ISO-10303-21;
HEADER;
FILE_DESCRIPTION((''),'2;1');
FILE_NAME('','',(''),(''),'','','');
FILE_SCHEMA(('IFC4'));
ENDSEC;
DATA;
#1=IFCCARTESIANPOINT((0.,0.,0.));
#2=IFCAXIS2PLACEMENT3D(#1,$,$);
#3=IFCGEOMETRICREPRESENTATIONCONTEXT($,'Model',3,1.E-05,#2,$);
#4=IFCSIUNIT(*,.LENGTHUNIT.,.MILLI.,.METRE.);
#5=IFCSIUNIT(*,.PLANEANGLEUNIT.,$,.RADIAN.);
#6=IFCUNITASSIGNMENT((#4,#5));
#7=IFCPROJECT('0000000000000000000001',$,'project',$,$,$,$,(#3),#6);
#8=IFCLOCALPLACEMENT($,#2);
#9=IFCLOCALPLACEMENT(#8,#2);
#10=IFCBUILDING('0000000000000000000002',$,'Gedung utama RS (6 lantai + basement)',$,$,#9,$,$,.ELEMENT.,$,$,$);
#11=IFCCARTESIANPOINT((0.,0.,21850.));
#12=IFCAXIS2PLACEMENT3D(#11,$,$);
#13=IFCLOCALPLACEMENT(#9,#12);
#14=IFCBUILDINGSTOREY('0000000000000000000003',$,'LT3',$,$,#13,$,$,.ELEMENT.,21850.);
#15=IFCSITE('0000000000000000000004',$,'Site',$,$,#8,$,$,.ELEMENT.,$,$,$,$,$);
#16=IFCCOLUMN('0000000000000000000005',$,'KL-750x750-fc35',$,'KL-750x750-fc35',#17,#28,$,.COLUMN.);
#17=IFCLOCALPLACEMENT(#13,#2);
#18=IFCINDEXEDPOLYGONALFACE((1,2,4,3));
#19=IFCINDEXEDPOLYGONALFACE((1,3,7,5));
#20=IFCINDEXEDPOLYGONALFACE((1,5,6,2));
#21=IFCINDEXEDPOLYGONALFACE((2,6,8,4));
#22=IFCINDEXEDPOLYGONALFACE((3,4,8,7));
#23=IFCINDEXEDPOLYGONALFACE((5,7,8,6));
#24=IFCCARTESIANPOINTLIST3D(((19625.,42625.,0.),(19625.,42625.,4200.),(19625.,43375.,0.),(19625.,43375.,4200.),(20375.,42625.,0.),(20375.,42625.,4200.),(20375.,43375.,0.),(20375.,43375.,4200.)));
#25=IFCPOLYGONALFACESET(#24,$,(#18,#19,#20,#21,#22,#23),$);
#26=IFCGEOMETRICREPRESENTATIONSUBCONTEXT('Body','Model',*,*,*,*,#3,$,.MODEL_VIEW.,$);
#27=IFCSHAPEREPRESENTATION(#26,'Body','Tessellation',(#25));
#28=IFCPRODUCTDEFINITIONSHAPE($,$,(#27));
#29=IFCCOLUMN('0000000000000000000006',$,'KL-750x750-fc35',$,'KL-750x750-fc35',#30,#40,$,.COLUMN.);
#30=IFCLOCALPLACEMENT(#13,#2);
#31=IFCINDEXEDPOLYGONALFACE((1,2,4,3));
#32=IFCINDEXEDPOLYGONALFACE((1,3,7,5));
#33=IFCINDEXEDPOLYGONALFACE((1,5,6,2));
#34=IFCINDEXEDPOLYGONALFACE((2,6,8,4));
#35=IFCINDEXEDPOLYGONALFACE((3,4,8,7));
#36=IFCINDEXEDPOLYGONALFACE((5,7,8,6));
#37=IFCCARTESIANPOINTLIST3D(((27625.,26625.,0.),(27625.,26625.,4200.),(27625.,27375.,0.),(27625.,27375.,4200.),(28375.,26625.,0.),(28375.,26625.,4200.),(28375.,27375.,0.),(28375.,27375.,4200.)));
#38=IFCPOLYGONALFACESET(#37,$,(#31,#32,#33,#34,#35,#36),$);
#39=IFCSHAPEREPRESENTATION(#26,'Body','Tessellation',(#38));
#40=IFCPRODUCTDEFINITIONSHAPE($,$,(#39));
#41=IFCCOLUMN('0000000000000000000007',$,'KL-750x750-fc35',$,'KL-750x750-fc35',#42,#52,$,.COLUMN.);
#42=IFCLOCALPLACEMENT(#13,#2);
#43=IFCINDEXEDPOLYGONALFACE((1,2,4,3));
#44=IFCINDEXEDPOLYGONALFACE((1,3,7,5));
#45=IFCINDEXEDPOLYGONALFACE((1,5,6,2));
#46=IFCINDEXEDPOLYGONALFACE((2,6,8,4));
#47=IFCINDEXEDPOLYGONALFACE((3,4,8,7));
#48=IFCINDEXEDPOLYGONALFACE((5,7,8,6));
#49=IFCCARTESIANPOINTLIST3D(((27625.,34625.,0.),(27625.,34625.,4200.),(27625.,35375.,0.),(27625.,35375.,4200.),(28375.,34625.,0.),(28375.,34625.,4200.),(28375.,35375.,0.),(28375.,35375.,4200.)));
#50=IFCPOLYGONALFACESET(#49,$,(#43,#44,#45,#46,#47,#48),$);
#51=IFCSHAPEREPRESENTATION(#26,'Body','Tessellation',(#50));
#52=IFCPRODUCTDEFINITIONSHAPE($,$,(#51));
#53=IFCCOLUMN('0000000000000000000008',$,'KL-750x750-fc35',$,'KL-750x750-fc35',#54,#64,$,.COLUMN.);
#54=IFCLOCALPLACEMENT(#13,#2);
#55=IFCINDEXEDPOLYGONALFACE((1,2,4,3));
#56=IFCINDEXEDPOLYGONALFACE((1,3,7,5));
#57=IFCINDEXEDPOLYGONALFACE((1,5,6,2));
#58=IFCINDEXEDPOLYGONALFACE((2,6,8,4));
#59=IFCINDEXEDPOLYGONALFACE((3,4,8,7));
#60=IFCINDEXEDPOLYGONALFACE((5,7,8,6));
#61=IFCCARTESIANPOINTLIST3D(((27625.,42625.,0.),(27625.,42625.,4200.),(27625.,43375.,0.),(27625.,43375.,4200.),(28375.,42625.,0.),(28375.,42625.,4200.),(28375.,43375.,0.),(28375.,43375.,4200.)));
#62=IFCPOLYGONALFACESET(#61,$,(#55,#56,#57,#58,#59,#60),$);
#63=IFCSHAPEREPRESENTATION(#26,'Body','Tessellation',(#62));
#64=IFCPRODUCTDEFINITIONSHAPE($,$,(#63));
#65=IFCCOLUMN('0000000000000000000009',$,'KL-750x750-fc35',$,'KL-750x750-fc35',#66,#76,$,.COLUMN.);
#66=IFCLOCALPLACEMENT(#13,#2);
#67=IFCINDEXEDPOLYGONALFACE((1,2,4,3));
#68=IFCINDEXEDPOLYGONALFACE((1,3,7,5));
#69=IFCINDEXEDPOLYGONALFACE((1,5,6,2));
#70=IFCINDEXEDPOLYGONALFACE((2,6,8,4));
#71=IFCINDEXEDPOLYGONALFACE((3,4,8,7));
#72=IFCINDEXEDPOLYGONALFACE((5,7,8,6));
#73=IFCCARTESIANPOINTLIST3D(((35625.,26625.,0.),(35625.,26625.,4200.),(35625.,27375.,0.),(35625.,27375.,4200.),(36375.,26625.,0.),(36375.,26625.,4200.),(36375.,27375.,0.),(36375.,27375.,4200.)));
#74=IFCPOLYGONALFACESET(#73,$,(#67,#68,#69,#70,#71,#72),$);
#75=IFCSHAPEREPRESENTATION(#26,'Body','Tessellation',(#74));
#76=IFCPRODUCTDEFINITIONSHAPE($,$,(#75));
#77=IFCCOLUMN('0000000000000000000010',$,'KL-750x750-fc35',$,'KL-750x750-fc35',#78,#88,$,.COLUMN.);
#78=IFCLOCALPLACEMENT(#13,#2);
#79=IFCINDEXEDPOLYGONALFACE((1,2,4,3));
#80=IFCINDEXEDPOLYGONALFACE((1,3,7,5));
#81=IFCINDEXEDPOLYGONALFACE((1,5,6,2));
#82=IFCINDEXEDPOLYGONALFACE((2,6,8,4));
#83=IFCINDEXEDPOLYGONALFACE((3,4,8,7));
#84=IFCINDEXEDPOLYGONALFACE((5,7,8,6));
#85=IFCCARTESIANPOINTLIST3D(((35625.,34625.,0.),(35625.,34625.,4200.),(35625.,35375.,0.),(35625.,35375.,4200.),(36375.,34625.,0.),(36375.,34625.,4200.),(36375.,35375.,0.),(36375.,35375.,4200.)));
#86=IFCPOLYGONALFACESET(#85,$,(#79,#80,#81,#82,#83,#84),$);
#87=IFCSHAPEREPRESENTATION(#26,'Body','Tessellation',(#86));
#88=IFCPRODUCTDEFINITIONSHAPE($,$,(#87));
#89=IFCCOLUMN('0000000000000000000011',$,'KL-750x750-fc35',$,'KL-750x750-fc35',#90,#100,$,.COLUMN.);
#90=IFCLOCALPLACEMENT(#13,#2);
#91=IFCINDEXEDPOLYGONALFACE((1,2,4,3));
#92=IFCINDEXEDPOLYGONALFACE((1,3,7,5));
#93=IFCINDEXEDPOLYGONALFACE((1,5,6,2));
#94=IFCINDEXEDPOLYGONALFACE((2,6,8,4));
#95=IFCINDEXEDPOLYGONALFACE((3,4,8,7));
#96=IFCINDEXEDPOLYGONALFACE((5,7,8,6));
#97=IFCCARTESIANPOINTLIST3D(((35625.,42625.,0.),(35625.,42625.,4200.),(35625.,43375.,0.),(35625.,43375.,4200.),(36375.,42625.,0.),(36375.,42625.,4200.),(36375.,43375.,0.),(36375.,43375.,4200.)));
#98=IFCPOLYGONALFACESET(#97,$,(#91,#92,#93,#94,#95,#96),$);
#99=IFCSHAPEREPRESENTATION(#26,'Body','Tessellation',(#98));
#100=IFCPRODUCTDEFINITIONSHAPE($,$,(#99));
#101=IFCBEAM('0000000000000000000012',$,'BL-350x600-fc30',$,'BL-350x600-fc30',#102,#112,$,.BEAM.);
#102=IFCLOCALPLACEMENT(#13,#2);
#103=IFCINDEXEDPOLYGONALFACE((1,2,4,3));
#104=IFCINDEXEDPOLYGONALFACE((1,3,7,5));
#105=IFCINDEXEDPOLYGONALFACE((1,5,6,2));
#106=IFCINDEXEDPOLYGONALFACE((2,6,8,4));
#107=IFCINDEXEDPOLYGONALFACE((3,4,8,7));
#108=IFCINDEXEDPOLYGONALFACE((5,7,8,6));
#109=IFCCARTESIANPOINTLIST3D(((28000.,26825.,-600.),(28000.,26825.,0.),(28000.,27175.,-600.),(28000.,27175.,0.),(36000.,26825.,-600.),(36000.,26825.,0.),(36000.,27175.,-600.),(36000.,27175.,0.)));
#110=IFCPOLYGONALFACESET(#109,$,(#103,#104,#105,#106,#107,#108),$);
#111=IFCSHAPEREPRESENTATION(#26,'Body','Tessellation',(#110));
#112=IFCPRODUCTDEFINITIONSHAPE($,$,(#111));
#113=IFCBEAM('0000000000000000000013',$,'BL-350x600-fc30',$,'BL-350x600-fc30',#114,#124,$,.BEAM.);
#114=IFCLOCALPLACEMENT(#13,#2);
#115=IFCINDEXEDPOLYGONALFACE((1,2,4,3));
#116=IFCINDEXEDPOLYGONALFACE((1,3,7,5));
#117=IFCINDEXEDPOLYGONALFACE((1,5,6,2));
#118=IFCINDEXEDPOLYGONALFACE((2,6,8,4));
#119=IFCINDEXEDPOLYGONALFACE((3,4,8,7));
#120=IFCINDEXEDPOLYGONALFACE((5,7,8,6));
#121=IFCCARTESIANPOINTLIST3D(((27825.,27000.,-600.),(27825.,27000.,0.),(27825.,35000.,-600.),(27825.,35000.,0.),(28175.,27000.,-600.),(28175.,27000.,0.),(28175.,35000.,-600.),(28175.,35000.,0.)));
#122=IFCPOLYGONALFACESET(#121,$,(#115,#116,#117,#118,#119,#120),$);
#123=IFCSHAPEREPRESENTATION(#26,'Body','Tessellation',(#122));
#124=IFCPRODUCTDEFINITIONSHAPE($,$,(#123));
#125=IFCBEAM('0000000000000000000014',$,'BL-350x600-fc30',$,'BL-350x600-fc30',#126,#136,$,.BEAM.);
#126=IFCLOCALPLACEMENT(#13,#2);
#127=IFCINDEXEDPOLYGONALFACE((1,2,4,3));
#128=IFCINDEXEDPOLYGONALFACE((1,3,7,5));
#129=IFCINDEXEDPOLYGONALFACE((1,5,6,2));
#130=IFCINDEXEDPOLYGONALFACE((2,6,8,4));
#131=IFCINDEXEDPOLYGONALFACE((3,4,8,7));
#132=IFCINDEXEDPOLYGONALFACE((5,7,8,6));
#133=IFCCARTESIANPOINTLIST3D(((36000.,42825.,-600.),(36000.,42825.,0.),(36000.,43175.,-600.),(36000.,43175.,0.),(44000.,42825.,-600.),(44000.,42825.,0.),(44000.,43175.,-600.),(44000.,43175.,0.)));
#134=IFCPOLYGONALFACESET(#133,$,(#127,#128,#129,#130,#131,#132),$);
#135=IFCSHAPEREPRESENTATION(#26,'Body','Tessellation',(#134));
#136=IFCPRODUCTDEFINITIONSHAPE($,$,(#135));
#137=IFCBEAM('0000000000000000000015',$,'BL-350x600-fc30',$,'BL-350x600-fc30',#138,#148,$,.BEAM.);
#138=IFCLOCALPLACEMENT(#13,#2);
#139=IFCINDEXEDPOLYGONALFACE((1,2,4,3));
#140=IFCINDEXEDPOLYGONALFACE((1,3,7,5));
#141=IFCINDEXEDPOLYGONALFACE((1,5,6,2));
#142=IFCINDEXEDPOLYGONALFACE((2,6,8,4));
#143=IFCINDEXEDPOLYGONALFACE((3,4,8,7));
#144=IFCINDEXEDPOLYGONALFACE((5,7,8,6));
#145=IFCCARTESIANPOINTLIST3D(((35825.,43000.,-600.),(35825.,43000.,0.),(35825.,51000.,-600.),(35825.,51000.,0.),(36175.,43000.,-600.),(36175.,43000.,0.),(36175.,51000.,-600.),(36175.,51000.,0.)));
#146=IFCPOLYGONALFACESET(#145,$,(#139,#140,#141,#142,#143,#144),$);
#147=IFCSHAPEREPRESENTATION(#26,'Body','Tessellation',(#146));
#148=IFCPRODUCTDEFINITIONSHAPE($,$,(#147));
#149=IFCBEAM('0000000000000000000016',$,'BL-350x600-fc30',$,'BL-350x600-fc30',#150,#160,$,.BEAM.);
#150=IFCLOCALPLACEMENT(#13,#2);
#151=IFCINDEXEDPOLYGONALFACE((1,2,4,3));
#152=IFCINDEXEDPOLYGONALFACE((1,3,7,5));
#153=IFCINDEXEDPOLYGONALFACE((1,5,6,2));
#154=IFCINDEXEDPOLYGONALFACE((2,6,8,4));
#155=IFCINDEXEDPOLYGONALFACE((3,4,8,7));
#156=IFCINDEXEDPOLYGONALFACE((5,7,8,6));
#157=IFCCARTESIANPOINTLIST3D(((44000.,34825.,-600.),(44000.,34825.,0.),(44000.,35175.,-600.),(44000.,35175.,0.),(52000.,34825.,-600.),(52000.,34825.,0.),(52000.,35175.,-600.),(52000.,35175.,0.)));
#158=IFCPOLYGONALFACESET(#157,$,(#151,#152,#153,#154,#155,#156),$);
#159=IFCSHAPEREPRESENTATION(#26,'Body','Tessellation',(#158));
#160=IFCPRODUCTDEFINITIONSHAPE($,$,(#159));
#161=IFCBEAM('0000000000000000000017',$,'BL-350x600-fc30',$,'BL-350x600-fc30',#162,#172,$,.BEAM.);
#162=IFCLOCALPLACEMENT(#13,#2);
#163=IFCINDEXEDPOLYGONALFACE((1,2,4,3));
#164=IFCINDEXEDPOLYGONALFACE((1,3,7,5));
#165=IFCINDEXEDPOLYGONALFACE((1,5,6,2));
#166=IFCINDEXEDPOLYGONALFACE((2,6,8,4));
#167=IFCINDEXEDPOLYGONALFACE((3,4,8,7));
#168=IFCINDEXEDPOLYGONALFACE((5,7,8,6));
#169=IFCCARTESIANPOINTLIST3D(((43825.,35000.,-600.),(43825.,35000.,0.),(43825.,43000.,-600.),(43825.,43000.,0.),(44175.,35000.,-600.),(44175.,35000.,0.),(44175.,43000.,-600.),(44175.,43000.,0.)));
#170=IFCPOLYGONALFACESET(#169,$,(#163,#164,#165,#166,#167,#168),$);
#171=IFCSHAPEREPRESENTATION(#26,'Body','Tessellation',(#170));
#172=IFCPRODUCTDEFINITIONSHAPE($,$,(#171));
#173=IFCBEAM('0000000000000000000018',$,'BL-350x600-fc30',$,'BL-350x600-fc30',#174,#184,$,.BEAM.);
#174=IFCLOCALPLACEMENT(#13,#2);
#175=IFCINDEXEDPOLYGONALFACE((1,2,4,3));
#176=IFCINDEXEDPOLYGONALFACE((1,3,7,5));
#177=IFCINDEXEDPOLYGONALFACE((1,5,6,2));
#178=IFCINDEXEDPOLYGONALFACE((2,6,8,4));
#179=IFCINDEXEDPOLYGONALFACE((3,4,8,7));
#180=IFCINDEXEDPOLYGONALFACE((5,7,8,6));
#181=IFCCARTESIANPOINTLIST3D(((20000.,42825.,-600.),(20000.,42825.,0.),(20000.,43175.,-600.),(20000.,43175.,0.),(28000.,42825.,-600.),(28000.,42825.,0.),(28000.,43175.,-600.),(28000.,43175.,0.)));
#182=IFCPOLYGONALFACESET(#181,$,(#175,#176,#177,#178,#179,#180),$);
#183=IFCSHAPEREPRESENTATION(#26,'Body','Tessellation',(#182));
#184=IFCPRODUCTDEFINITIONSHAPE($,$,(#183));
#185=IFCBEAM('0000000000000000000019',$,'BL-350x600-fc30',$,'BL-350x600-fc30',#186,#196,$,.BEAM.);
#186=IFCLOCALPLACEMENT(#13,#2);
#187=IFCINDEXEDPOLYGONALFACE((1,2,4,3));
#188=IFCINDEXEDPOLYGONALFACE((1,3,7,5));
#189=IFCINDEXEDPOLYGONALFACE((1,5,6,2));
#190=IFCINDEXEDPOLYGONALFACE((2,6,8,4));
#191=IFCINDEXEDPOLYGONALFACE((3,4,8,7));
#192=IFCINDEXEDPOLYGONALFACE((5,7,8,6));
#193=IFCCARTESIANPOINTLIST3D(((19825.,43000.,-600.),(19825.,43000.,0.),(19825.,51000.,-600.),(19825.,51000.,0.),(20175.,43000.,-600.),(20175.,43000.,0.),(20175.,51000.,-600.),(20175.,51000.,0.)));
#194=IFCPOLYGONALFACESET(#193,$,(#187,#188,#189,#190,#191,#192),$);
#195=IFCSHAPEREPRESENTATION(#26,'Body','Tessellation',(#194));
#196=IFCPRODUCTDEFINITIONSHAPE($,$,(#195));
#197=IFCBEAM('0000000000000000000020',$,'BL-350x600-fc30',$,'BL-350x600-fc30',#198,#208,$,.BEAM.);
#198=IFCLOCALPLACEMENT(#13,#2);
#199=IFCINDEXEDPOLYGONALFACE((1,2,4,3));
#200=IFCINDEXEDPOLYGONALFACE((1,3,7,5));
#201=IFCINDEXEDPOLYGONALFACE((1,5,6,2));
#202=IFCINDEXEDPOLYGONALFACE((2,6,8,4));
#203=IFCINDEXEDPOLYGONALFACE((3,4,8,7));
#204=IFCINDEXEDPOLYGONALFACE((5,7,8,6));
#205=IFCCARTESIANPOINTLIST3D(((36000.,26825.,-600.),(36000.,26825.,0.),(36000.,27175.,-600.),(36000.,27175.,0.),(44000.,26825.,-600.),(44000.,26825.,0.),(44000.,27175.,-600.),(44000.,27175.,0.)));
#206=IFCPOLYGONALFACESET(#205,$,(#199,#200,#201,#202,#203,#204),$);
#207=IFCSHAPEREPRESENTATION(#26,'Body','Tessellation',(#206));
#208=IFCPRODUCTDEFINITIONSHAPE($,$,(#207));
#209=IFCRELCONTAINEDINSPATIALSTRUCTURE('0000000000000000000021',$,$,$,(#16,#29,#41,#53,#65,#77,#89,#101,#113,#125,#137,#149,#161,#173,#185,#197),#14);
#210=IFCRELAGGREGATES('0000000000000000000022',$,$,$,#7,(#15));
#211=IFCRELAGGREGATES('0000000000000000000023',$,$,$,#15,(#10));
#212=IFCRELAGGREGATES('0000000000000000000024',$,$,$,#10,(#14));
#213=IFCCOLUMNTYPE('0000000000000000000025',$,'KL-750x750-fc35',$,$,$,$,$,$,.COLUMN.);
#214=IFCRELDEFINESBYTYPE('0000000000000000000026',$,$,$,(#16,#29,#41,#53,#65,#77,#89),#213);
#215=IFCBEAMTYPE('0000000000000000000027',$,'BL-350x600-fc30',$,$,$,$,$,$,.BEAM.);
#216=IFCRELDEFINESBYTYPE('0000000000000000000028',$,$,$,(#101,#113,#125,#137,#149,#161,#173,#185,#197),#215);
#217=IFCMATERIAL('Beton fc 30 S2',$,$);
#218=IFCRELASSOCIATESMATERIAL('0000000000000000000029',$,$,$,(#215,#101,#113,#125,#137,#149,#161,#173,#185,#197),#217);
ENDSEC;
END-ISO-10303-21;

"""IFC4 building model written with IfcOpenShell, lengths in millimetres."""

from ifc_helpers import new_model, si_unit, frame, origin, origin_2d, place, context, subcontext, project, spatial, rectangle, extrude, material, material_profile, profile_set, profile_usage, type_object, element, save


model = new_model("IFC4")

# Units and contexts
model_context = context("Model", 3, precision=1e-05, world=origin())
body_context = subcontext(model_context, "Body", "Model", "MODEL_VIEW")
ifc_project = project(units=[si_unit("LENGTHUNIT", "METRE", prefix="MILLI"), si_unit("PLANEANGLEUNIT", "RADIAN")], contexts=[model_context])

# Site, building, storey
site_placement = place(None, origin())
site = spatial("IfcSite", under=ifc_project, at=site_placement, Name="Site", CompositionType="ELEMENT")
building_placement = place(site_placement, origin())
building = spatial("IfcBuilding", under=site, at=building_placement, Name="Gedung utama RS (6 lantai + basement)", CompositionType="ELEMENT")
storey_placement = place(building_placement, frame((0.0, 0.0, 21850.0)))
storey = spatial("IfcBuildingStorey", under=building, at=storey_placement, Name="LT3", CompositionType="ELEMENT", Elevation=21850.0)

# Columns
ifc_material_profile_1 = material_profile(None, rectangle(XDim=750.0, YDim=750.0, at=origin_2d()), Name="KL-750x750-fc35")
ifc_profile_set_1 = profile_set([ifc_material_profile_1], Name="KL-750x750-fc35")
ifc_profile_usage_1 = profile_usage(ifc_profile_set_1, cardinal=5)
column_type = type_object("IfcColumnType", Name="KL-750x750-fc35", PredefinedType="COLUMN", material=ifc_profile_set_1)
for number, where, z_axis, x_axis, name in (
    (1, (20000.0, 43000.0, 0.0), (0.0, 0.0, 1.0), (1.0, 0.0, 0.0), "KL-750x750-fc35"),
    (2, (28000.0, 27000.0, 0.0), (0.0, 0.0, 1.0), (1.0, 0.0, 0.0), "KL-750x750-fc35"),
    (3, (28000.0, 35000.0, 0.0), (0.0, 0.0, 1.0), (1.0, 0.0, 0.0), "KL-750x750-fc35"),
    (4, (28000.0, 43000.0, 0.0), (0.0, 0.0, 1.0), (1.0, 0.0, 0.0), "KL-750x750-fc35"),
    (5, (36000.0, 27000.0, 0.0), (0.0, 0.0, 1.0), (1.0, 0.0, 0.0), "KL-750x750-fc35"),
    (6, (36000.0, 35000.0, 0.0), (0.0, 0.0, 1.0), (1.0, 0.0, 0.0), "KL-750x750-fc35"),
    (7, (36000.0, 43000.0, 0.0), (0.0, 0.0, 1.0), (1.0, 0.0, 0.0), "KL-750x750-fc35"),
):
    element("IfcColumn", number, at=place(storey_placement, frame(where, z_axis=z_axis, x_axis=x_axis)), inside=storey, type_object=column_type, material=ifc_profile_usage_1, Name=name, ObjectType="KL-750x750-fc35", PredefinedType="COLUMN", context=body_context, shape_type="SweptSolid", body=[
        extrude(rectangle(XDim=750.0, YDim=750.0, at=origin_2d()), origin(), (0.0, 0.0, 1.0), 4200.0),
    ])

# Beams
ifc_material_1 = material(Name="Beton fc 30 S2")
ifc_material_profile_2 = material_profile(ifc_material_1, rectangle(XDim=350.0, YDim=600.0, at=origin_2d()), Name="BL-350x600-fc30")
ifc_profile_set_2 = profile_set([ifc_material_profile_2], Name="BL-350x600-fc30")
ifc_profile_usage_2 = profile_usage(ifc_profile_set_2, cardinal=8)
beam_type = type_object("IfcBeamType", Name="BL-350x600-fc30", PredefinedType="BEAM", material=ifc_profile_set_2)
beam_1_placement = place(storey_placement, frame((28000.0, 27000.0, -300.0)))
element("IfcBeam", 8, at=beam_1_placement, inside=storey, type_object=beam_type, material=ifc_profile_usage_2, Name="BL-350x600-fc30", ObjectType="BL-350x600-fc30", PredefinedType="BEAM", context=body_context, shape_type="SweptSolid", body=[
    extrude(rectangle(XDim=350.0, YDim=600.0, at=origin_2d()), frame((0.0, 0.0, 0.0), z_axis=(1.0, 0.0, 0.0), x_axis=(0.0, 1.0, 0.0)), (0.0, 0.0, 1.0), 8000.0),
])
beam_2_placement = place(storey_placement, frame((28000.0, 27000.0, -300.0)))
element("IfcBeam", 9, at=beam_2_placement, inside=storey, type_object=beam_type, material=ifc_profile_usage_2, Name="BL-350x600-fc30", ObjectType="BL-350x600-fc30", PredefinedType="BEAM", context=body_context, shape_type="SweptSolid", body=[
    extrude(rectangle(XDim=350.0, YDim=600.0, at=origin_2d()), frame((0.0, 0.0, 0.0), z_axis=(0.0, 1.0, 0.0), x_axis=(-1.0, 0.0, 0.0)), (0.0, 0.0, 1.0), 8000.0),
])
beam_3_placement = place(storey_placement, frame((36000.0, 43000.0, -300.0)))
element("IfcBeam", 10, at=beam_3_placement, inside=storey, type_object=beam_type, material=ifc_profile_usage_2, Name="BL-350x600-fc30", ObjectType="BL-350x600-fc30", PredefinedType="BEAM", context=body_context, shape_type="SweptSolid", body=[
    extrude(rectangle(XDim=350.0, YDim=600.0, at=origin_2d()), frame((0.0, 0.0, 0.0), z_axis=(1.0, 0.0, 0.0), x_axis=(0.0, 1.0, 0.0)), (0.0, 0.0, 1.0), 8000.0),
])
beam_4_placement = place(storey_placement, frame((36000.0, 43000.0, -300.0)))
element("IfcBeam", 11, at=beam_4_placement, inside=storey, type_object=beam_type, material=ifc_profile_usage_2, Name="BL-350x600-fc30", ObjectType="BL-350x600-fc30", PredefinedType="BEAM", context=body_context, shape_type="SweptSolid", body=[
    extrude(rectangle(XDim=350.0, YDim=600.0, at=origin_2d()), frame((0.0, 0.0, 0.0), z_axis=(0.0, 1.0, 0.0), x_axis=(-1.0, 0.0, 0.0)), (0.0, 0.0, 1.0), 8000.0),
])
beam_5_placement = place(storey_placement, frame((44000.0, 35000.0, -300.0)))
element("IfcBeam", 12, at=beam_5_placement, inside=storey, type_object=beam_type, material=ifc_profile_usage_2, Name="BL-350x600-fc30", ObjectType="BL-350x600-fc30", PredefinedType="BEAM", context=body_context, shape_type="SweptSolid", body=[
    extrude(rectangle(XDim=350.0, YDim=600.0, at=origin_2d()), frame((0.0, 0.0, 0.0), z_axis=(1.0, 0.0, 0.0), x_axis=(0.0, 1.0, 0.0)), (0.0, 0.0, 1.0), 8000.0),
])
beam_6_placement = place(storey_placement, frame((44000.0, 35000.0, -300.0)))
element("IfcBeam", 13, at=beam_6_placement, inside=storey, type_object=beam_type, material=ifc_profile_usage_2, Name="BL-350x600-fc30", ObjectType="BL-350x600-fc30", PredefinedType="BEAM", context=body_context, shape_type="SweptSolid", body=[
    extrude(rectangle(XDim=350.0, YDim=600.0, at=origin_2d()), frame((0.0, 0.0, 0.0), z_axis=(0.0, 1.0, 0.0), x_axis=(-1.0, 0.0, 0.0)), (0.0, 0.0, 1.0), 8000.0),
])
beam_7_placement = place(storey_placement, frame((20000.0, 43000.0, -300.0)))
element("IfcBeam", 14, at=beam_7_placement, inside=storey, type_object=beam_type, material=ifc_profile_usage_2, Name="BL-350x600-fc30", ObjectType="BL-350x600-fc30", PredefinedType="BEAM", context=body_context, shape_type="SweptSolid", body=[
    extrude(rectangle(XDim=350.0, YDim=600.0, at=origin_2d()), frame((0.0, 0.0, 0.0), z_axis=(1.0, 0.0, 0.0), x_axis=(0.0, 1.0, 0.0)), (0.0, 0.0, 1.0), 8000.0),
])
beam_8_placement = place(storey_placement, frame((20000.0, 43000.0, -300.0)))
element("IfcBeam", 15, at=beam_8_placement, inside=storey, type_object=beam_type, material=ifc_profile_usage_2, Name="BL-350x600-fc30", ObjectType="BL-350x600-fc30", PredefinedType="BEAM", context=body_context, shape_type="SweptSolid", body=[
    extrude(rectangle(XDim=350.0, YDim=600.0, at=origin_2d()), frame((0.0, 0.0, 0.0), z_axis=(0.0, 1.0, 0.0), x_axis=(-1.0, 0.0, 0.0)), (0.0, 0.0, 1.0), 8000.0),
])
beam_9_placement = place(storey_placement, frame((36000.0, 27000.0, -300.0)))
element("IfcBeam", 16, at=beam_9_placement, inside=storey, type_object=beam_type, material=ifc_profile_usage_2, Name="BL-350x600-fc30", ObjectType="BL-350x600-fc30", PredefinedType="BEAM", context=body_context, shape_type="SweptSolid", body=[
    extrude(rectangle(XDim=350.0, YDim=600.0, at=origin_2d()), frame((0.0, 0.0, 0.0), z_axis=(1.0, 0.0, 0.0), x_axis=(0.0, 1.0, 0.0)), (0.0, 0.0, 1.0), 8000.0),
])

save(model, "model.ifc")
